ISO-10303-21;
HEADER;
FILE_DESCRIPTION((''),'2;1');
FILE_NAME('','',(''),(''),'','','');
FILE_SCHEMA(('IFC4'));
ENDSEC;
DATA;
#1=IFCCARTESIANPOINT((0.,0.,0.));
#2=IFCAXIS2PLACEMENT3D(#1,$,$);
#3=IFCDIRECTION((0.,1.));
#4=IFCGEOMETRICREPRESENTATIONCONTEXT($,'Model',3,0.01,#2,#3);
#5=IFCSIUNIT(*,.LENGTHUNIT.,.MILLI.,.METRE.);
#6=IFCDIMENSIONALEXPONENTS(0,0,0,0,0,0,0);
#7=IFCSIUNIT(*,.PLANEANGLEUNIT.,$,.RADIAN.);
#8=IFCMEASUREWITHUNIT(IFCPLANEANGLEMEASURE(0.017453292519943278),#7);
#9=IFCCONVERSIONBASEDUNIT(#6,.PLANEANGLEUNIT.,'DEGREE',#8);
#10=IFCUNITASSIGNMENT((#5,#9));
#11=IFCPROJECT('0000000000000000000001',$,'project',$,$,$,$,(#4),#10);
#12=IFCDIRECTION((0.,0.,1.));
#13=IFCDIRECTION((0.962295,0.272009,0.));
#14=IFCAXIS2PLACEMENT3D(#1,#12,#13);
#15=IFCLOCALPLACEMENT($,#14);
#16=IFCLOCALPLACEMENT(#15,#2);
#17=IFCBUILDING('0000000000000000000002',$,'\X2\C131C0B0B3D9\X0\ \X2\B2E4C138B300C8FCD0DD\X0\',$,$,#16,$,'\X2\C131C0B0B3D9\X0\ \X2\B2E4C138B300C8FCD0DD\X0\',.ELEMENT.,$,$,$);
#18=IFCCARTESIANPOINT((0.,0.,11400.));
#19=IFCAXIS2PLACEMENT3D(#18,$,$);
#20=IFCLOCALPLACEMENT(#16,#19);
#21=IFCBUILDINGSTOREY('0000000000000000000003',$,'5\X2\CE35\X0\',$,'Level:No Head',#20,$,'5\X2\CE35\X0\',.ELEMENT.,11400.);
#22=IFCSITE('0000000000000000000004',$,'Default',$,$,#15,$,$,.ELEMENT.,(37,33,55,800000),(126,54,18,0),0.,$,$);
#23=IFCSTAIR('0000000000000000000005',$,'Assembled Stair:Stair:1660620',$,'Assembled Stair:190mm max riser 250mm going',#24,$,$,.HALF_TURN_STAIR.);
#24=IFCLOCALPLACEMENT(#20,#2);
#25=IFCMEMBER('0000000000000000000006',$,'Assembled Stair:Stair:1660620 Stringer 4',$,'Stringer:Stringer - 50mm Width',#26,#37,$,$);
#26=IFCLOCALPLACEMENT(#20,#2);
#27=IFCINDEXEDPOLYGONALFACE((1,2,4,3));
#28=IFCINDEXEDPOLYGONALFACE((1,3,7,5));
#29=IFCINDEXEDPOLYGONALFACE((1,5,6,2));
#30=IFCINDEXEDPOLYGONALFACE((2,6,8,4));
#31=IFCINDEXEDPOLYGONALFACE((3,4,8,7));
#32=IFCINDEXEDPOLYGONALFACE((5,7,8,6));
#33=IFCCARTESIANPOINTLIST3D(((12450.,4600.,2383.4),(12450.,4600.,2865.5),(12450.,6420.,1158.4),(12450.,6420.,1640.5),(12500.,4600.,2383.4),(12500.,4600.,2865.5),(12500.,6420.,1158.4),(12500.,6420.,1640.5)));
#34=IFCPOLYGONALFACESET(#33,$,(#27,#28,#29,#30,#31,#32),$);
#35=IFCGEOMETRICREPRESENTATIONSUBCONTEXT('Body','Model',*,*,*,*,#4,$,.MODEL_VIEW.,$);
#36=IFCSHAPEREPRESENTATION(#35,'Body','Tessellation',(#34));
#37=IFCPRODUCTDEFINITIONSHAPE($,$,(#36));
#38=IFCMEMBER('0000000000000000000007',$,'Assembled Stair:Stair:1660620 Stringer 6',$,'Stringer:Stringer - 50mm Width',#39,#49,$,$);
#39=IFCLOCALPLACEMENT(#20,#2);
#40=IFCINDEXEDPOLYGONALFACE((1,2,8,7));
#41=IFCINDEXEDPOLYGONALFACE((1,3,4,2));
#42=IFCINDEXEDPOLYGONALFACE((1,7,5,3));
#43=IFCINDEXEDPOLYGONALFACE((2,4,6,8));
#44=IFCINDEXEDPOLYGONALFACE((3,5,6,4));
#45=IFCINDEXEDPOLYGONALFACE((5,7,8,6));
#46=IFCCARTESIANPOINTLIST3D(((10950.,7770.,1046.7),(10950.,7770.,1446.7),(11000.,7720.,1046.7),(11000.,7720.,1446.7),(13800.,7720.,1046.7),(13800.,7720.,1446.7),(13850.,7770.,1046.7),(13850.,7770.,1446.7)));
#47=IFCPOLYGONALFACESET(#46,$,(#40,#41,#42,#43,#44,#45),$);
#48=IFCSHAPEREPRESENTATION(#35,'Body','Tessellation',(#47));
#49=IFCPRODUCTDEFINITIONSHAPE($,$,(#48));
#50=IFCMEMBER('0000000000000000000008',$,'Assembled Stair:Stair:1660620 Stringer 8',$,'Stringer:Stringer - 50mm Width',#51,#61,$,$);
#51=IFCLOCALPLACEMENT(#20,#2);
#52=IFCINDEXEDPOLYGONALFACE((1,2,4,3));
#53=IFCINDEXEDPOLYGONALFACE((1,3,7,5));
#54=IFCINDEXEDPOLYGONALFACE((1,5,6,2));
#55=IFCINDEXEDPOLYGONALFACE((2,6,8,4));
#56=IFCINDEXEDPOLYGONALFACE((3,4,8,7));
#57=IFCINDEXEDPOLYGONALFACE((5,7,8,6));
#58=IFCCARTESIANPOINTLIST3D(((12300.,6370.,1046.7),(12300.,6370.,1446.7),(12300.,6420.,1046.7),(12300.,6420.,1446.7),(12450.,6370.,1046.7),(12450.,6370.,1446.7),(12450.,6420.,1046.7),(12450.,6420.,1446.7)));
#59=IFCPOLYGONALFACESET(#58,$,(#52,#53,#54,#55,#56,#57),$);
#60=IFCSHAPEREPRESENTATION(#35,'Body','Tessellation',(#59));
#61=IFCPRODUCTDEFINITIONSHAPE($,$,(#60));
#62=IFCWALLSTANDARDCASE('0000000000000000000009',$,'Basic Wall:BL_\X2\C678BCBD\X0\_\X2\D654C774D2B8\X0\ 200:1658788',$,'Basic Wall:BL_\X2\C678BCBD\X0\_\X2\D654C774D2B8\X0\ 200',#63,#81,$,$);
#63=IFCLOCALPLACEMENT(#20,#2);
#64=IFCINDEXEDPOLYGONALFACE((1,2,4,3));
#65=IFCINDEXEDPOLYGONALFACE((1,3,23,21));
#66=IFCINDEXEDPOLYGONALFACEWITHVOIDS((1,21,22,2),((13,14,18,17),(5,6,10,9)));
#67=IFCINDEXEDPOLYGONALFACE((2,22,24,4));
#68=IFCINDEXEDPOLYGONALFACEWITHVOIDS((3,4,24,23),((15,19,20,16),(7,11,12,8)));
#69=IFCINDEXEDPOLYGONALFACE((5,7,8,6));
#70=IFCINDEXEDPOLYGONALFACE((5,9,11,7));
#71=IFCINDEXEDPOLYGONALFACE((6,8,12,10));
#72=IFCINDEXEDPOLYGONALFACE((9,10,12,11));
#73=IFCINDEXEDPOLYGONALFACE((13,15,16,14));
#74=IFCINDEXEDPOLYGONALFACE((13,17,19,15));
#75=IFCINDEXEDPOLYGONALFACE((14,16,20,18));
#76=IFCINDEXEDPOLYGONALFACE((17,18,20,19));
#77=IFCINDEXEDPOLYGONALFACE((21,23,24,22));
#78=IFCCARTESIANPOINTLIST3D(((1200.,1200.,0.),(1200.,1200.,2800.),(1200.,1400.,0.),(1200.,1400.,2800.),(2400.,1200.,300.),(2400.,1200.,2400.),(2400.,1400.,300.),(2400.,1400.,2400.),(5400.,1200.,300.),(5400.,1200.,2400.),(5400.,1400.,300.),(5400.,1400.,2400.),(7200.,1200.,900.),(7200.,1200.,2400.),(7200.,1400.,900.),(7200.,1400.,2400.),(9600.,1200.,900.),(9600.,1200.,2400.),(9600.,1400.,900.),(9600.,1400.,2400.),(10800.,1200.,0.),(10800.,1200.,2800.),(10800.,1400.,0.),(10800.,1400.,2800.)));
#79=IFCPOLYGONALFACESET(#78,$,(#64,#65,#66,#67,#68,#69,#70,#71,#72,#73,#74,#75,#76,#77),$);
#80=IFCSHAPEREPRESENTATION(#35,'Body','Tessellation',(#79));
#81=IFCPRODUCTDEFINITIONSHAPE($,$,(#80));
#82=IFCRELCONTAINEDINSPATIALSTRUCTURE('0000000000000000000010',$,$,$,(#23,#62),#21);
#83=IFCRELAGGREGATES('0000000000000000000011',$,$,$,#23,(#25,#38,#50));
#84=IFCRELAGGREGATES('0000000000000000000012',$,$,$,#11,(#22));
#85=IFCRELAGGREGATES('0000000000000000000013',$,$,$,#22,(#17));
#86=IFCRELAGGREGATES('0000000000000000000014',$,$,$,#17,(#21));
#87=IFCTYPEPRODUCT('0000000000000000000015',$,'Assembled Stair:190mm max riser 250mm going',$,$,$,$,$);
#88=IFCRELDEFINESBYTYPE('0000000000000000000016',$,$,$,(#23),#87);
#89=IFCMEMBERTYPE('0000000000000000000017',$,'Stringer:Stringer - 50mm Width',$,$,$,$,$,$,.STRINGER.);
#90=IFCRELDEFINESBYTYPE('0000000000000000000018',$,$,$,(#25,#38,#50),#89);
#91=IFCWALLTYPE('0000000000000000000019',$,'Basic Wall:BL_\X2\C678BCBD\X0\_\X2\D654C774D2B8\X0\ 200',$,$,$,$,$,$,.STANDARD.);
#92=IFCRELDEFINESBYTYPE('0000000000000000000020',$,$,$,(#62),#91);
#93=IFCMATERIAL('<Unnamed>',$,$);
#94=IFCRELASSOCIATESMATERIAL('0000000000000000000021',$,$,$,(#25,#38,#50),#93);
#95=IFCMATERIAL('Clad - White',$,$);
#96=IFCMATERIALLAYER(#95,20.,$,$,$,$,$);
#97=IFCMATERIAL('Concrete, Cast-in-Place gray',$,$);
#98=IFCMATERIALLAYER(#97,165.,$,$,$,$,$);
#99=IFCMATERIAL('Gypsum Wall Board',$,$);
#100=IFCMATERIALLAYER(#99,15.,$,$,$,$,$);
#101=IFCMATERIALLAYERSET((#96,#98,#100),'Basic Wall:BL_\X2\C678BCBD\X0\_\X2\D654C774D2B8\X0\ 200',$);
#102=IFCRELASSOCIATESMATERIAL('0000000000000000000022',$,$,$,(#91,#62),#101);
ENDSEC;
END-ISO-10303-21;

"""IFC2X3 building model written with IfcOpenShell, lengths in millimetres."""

from ifc_helpers import new_model, entity, si_unit, converted_unit, direction, frame, frame_2d, origin, origin_2d_with_axis, place, context, subcontext, project, spatial, polyline, rectangle, outline, extrude, material, layer, layer_set, layer_usage, type_object, element, aggregate, save


model = new_model("IFC2X3")

# Units and contexts
model_context = context("Model", 3, precision=0.01, world=origin(), true_north=direction((0.0, 1.0)))
body_context = subcontext(model_context, "Body", "Model", "MODEL_VIEW")
ifc_project = project(units=[si_unit("LENGTHUNIT", "METRE", prefix="MILLI"), converted_unit("PLANEANGLEUNIT", "DEGREE", entity("IfcPlaneAngleMeasure", 0.017453292519943278), si_unit("PLANEANGLEUNIT", "RADIAN"), dimensions=[0, 0, 0, 0, 0, 0, 0])], contexts=[model_context])

# Site, building, storey
site_placement = place(None, frame((0.0, 0.0, 0.0), z_axis=(0.0, 0.0, 1.0), x_axis=(0.962295, 0.272009, 0.0)))
site = spatial("IfcSite", under=ifc_project, at=site_placement, Name="Default", CompositionType="ELEMENT", RefLatitude=(37, 33, 55, 800000), RefLongitude=(126, 54, 18, 0), RefElevation=0.0)
building_placement = place(site_placement, origin())
building = spatial("IfcBuilding", under=site, at=building_placement, Name="성산동 다세대주택", LongName="성산동 다세대주택", CompositionType="ELEMENT")
storey_placement = place(building_placement, frame((0.0, 0.0, 11400.0)))
storey = spatial("IfcBuildingStorey", under=building, at=storey_placement, Name="5층", ObjectType="Level:No Head", LongName="5층", CompositionType="ELEMENT", Elevation=11400.0)

# Stair, members
type_product = type_object("IfcTypeProduct", Name="Assembled Stair:190mm max riser 250mm going")
stair_placement = place(storey_placement, origin())
stair = element("IfcStair", 1, at=stair_placement, inside=storey, type_object=type_product, Name="Assembled Stair:Stair:1660620", ObjectType="Assembled Stair:190mm max riser 250mm going", ShapeType="HALF_TURN_STAIR")
ifc_material_1 = material(Name="<Unnamed>")
member_type = type_object("IfcMemberType", Name="Stringer:Stringer - 50mm Width", PredefinedType="STRINGER")
member_1_placement = place(stair_placement, origin())
member_1 = element("IfcMember", 2, at=member_1_placement, type_object=member_type, material=ifc_material_1, Name="Assembled Stair:Stair:1660620 Stringer 4", ObjectType="Stringer:Stringer - 50mm Width", context=body_context, shape_type="SweptSolid", body=[
    extrude(outline(polyline([(-962.3, -200.0), (1231.5, -200.0), (962.3, 200.0), (-1231.5, 200.0), (-962.3, -200.0)])), frame((12450.0, 5510.0, 2011.9), z_axis=(1.0, 0.0, 0.0), x_axis=(0.0, -0.829588, 0.558376)), (0.0, 0.0, 1.0), 50.0),
])
member_2_placement = place(stair_placement, origin())
member_2 = element("IfcMember", 3, at=member_2_placement, type_object=member_type, material=ifc_material_1, Name="Assembled Stair:Stair:1660620 Stringer 6", ObjectType="Stringer:Stringer - 50mm Width", context=body_context, shape_type="SweptSolid", body=[
    extrude(outline(polyline([(-1450.0, -25.0), (1450.0, -25.0), (1400.0, 25.0), (-1400.0, 25.0), (-1450.0, -25.0)])), frame((12400.0, 7745.0, 1046.7), z_axis=(0.0, 0.0, 1.0), x_axis=(-1.0, 0.0, 0.0)), (0.0, 0.0, 1.0), 400.0),
])
member_3_placement = place(stair_placement, origin())
member_3 = element("IfcMember", 4, at=member_3_placement, type_object=member_type, material=ifc_material_1, Name="Assembled Stair:Stair:1660620 Stringer 8", ObjectType="Stringer:Stringer - 50mm Width", context=body_context, shape_type="SweptSolid", body=[
    extrude(rectangle(XDim=150.0, YDim=50.0, at=origin_2d_with_axis()), frame((12375.0, 6395.0, 1046.7)), (0.0, 0.0, 1.0), 400.0),
])

# Shared definitions
ifc_material_2 = material(Name="Concrete, Cast-in-Place gray")

# Wall, openings
ifc_material_3 = material(Name="Clad - White")
ifc_layer_1 = layer(ifc_material_3, 20.0)
ifc_layer_2 = layer(ifc_material_2, 165.0)
ifc_material_4 = material(Name="Gypsum Wall Board")
ifc_layer_3 = layer(ifc_material_4, 15.0)
ifc_layer_set_1 = layer_set([ifc_layer_1, ifc_layer_2, ifc_layer_3], Name="Basic Wall:BL_외벽_화이트 200")
ifc_layer_usage_1 = layer_usage(ifc_layer_set_1, "AXIS2", "POSITIVE", -100.0)
wall_type = type_object("IfcWallType", Name="Basic Wall:BL_외벽_화이트 200", PredefinedType="STANDARD", material=ifc_layer_set_1)
wall_placement = place(storey_placement, frame((1200.0, 1300.0, 0.0)))
wall = element("IfcWallStandardCase", 5, at=wall_placement, inside=storey, type_object=wall_type, material=ifc_layer_usage_1, Name="Basic Wall:BL_외벽_화이트 200:1658788", ObjectType="Basic Wall:BL_외벽_화이트 200", context=body_context, shape_type="SweptSolid", body=[
    extrude(rectangle(XDim=9600.0, YDim=200.0, at=frame_2d((4800.0, 0.0), x_axis=(-1.0, 0.0))), origin(), (0.0, 0.0, 1.0), 2800.0),
])
opening_1_placement = place(wall_placement, frame((1200.0, -100.0, 300.0)))
element("IfcOpeningElement", 6, at=opening_1_placement, cuts=wall, ObjectType="Opening", context=body_context, shape_type="SweptSolid", body=[
    extrude(rectangle(XDim=2100.0, YDim=3000.0, at=frame_2d((1050.0, 1500.0), x_axis=(-1.0, 0.0))), frame((0.0, 0.0, 0.0), z_axis=(0.0, 1.0, 0.0), x_axis=(0.0, 0.0, 1.0)), (0.0, 0.0, 1.0), 200.0),
])
opening_2_placement = place(wall_placement, frame((6000.0, -100.0, 900.0)))
element("IfcOpeningElement", 7, at=opening_2_placement, cuts=wall, ObjectType="Opening", context=body_context, shape_type="SweptSolid", body=[
    extrude(rectangle(XDim=1500.0, YDim=2400.0, at=frame_2d((750.0, 1200.0), x_axis=(-1.0, 0.0))), frame((0.0, 0.0, 0.0), z_axis=(0.0, 1.0, 0.0), x_axis=(0.0, 0.0, 1.0)), (0.0, 0.0, 1.0), 200.0),
])

aggregate(stair, [member_1, member_2, member_3])

save(model, "model.ifc")
